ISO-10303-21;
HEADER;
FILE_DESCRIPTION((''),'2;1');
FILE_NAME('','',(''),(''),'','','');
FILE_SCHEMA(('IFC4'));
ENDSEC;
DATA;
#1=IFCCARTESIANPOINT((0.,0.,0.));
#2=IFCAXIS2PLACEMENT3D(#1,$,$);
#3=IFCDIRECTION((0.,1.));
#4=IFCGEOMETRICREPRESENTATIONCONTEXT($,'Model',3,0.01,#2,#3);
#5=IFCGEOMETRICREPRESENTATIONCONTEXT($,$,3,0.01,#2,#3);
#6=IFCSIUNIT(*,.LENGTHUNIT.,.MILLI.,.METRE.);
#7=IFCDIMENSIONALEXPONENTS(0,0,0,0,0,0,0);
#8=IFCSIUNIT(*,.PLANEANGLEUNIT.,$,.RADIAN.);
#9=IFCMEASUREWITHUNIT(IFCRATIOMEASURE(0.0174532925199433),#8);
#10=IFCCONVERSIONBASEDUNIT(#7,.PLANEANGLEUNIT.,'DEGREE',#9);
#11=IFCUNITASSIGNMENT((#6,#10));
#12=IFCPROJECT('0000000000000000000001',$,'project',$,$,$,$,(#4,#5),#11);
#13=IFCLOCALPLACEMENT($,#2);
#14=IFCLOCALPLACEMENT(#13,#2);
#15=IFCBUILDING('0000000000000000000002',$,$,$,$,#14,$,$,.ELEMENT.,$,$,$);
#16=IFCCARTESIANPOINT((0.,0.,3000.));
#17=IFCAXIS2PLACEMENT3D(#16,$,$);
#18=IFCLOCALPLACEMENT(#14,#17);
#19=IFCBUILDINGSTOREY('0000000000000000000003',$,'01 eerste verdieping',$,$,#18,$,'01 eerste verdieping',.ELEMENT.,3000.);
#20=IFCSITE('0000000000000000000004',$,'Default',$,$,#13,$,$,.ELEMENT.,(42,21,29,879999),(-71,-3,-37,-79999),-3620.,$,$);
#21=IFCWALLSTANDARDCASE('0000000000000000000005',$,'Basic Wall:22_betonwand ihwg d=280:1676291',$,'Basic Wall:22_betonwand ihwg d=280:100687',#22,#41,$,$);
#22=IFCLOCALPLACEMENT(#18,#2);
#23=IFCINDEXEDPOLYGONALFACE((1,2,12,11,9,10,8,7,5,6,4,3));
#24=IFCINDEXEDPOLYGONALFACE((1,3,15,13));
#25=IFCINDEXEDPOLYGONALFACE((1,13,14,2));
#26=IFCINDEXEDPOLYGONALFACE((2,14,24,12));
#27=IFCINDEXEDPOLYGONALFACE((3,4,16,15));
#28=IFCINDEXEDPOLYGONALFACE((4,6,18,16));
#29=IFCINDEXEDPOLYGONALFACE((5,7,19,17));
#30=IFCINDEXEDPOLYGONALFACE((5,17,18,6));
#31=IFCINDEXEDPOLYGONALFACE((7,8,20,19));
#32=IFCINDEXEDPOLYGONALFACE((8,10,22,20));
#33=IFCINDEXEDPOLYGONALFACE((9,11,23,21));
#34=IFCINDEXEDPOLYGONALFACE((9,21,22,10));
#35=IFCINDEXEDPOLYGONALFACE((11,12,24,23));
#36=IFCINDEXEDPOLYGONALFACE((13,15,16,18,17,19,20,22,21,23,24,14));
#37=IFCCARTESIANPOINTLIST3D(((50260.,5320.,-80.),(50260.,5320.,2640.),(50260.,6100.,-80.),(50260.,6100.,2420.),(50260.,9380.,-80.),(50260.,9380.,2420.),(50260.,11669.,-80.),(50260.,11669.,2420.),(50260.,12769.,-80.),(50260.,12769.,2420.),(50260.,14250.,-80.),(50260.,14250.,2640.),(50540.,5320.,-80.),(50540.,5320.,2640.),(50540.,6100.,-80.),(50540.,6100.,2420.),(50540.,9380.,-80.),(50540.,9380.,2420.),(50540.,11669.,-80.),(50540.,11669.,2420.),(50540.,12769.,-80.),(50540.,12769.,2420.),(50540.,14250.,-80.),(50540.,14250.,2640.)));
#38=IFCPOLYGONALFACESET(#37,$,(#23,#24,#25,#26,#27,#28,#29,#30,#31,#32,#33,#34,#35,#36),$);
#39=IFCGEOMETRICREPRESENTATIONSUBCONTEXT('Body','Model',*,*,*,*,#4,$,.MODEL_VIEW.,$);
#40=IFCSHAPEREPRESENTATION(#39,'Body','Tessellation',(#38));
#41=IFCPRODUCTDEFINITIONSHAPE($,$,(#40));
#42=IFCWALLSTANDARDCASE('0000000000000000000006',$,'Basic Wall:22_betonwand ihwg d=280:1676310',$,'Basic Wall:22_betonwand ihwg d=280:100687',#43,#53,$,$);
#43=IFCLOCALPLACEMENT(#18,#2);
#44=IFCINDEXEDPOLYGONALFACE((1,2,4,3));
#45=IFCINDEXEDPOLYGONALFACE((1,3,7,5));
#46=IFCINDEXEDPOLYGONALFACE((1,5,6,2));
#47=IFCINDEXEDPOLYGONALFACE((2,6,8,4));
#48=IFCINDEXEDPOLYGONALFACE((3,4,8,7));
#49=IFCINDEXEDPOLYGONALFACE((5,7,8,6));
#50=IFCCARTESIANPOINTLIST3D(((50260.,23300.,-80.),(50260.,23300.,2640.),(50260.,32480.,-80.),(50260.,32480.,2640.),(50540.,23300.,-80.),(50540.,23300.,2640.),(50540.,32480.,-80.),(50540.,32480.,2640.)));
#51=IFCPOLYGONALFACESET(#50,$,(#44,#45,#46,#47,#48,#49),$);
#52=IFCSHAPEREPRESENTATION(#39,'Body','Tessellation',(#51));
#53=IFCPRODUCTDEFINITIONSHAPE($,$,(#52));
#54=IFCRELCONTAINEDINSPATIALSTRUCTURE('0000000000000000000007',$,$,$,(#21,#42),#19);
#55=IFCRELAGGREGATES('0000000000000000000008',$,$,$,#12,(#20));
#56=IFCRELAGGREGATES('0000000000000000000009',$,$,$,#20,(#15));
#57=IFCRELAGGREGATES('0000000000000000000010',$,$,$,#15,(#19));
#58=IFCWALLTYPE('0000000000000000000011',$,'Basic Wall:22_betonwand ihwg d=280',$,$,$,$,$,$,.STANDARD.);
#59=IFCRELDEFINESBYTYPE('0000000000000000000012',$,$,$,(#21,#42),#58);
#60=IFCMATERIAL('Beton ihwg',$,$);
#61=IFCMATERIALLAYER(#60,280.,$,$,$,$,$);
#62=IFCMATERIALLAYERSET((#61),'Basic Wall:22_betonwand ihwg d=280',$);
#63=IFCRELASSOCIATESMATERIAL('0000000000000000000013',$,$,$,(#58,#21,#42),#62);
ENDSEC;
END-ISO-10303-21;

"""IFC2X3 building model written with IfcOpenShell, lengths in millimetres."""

from ifc_helpers import new_model, entity, si_unit, converted_unit, direction, frame, frame_2d, origin, place, context, subcontext, project, spatial, rectangle, extrude, material, layer, layer_set, layer_usage, type_object, element, save


model = new_model("IFC2X3")

# Units and contexts
model_context = context("Model", 3, precision=0.01, world=origin(), true_north=direction((0.0, 1.0)))
context_of_model = context(None, 3, precision=0.01, world=origin(), true_north=direction((0.0, 1.0)))
body_context = subcontext(model_context, "Body", "Model", "MODEL_VIEW")
ifc_project = project(units=[si_unit("LENGTHUNIT", "METRE", prefix="MILLI"), converted_unit("PLANEANGLEUNIT", "DEGREE", entity("IfcRatioMeasure", 0.0174532925199433), si_unit("PLANEANGLEUNIT", "RADIAN"), dimensions=[0, 0, 0, 0, 0, 0, 0])], contexts=[model_context, context_of_model])

# Site, building, storey
site_placement = place(None, origin())
site = spatial("IfcSite", under=ifc_project, at=site_placement, Name="Default", CompositionType="ELEMENT", RefLatitude=(42, 21, 29, 879999), RefLongitude=(-71, -3, -37, -79999), RefElevation=-3620.0)
building_placement = place(site_placement, origin())
building = spatial("IfcBuilding", under=site, at=building_placement, CompositionType="ELEMENT")
storey_placement = place(building_placement, frame((0.0, 0.0, 3000.0)))
storey = spatial("IfcBuildingStorey", under=building, at=storey_placement, Name="01 eerste verdieping", LongName="01 eerste verdieping", CompositionType="ELEMENT", Elevation=3000.0)

# Shared definitions
ifc_material_1 = material(Name="Beton ihwg")

# Wall, openings
ifc_layer_1 = layer(ifc_material_1, 280.0)
ifc_layer_set_1 = layer_set([ifc_layer_1], Name="Basic Wall:22_betonwand ihwg d=280")
ifc_layer_usage_1 = layer_usage(ifc_layer_set_1, "AXIS2", "NEGATIVE", 140.0)
wall_type_1 = type_object("IfcWallType", Name="Basic Wall:22_betonwand ihwg d=280", PredefinedType="STANDARD", material=ifc_layer_set_1)
wall_1_placement = place(storey_placement, frame((50400.0, 14250.0, -80.0), z_axis=(0.0, 0.0, 1.0), x_axis=(0.0, -1.0, 0.0)))
wall_1 = element("IfcWallStandardCase", 1, at=wall_1_placement, inside=storey, type_object=wall_type_1, material=ifc_layer_usage_1, Name="Basic Wall:22_betonwand ihwg d=280:1676291", ObjectType="Basic Wall:22_betonwand ihwg d=280:100687", context=body_context, shape_type="SweptSolid", body=[
    extrude(rectangle(XDim=8930.0, YDim=280.0, at=frame_2d((4465.0, 0.0), x_axis=(-1.0, 0.0))), origin(), (0.0, 0.0, 1.0), 2720.0),
])
opening_1_placement = place(wall_1_placement, frame((14250.0, -50400.0, 80.0), z_axis=(0.0, 0.0, 1.0), x_axis=(0.0, 1.0, 0.0)))
element("IfcOpeningElement", 2, at=opening_1_placement, cuts=wall_1, ObjectType="Opening", context=body_context, shape_type="SweptSolid", body=[
    extrude(rectangle(XDim=2500.0, YDim=3280.0, at=frame_2d((0.0, 0.0), x_axis=(0.0, 1.0))), frame((50000.0, 7740.0, 1170.0), z_axis=(1.0, 0.0, 0.0), x_axis=(0.0, -1.0, 0.0)), (0.0, 0.0, 1.0), 800.0),
])
opening_2_placement = place(wall_1_placement, frame((14250.0, -50400.0, 80.0), z_axis=(0.0, 0.0, 1.0), x_axis=(0.0, 1.0, 0.0)))
element("IfcOpeningElement", 3, at=opening_2_placement, cuts=wall_1, ObjectType="Opening", context=body_context, shape_type="SweptSolid", body=[
    extrude(rectangle(XDim=2500.0, YDim=1100.0, at=frame_2d((0.0, 0.0), x_axis=(0.0, 1.0))), frame((50000.0, 12219.0, 1170.0), z_axis=(1.0, 0.0, 0.0), x_axis=(0.0, -1.0, 0.0)), (0.0, 0.0, 1.0), 800.0),
])

# Wall
ifc_layer_usage_2 = layer_usage(ifc_layer_set_1, "AXIS2", "POSITIVE", -140.0)
wall_2_placement = place(storey_placement, frame((50400.0, 23300.0, -80.0), z_axis=(0.0, 0.0, 1.0), x_axis=(0.0, 1.0, 0.0)))
element("IfcWallStandardCase", 4, at=wall_2_placement, inside=storey, type_object=wall_type_1, material=ifc_layer_usage_2, Name="Basic Wall:22_betonwand ihwg d=280:1676310", ObjectType="Basic Wall:22_betonwand ihwg d=280:100687", context=body_context, shape_type="SweptSolid", body=[
    extrude(rectangle(XDim=9180.0, YDim=280.0, at=frame_2d((4590.0, 0.0), x_axis=(-1.0, 0.0))), origin(), (0.0, 0.0, 1.0), 2720.0),
])

save(model, "model.ifc")
